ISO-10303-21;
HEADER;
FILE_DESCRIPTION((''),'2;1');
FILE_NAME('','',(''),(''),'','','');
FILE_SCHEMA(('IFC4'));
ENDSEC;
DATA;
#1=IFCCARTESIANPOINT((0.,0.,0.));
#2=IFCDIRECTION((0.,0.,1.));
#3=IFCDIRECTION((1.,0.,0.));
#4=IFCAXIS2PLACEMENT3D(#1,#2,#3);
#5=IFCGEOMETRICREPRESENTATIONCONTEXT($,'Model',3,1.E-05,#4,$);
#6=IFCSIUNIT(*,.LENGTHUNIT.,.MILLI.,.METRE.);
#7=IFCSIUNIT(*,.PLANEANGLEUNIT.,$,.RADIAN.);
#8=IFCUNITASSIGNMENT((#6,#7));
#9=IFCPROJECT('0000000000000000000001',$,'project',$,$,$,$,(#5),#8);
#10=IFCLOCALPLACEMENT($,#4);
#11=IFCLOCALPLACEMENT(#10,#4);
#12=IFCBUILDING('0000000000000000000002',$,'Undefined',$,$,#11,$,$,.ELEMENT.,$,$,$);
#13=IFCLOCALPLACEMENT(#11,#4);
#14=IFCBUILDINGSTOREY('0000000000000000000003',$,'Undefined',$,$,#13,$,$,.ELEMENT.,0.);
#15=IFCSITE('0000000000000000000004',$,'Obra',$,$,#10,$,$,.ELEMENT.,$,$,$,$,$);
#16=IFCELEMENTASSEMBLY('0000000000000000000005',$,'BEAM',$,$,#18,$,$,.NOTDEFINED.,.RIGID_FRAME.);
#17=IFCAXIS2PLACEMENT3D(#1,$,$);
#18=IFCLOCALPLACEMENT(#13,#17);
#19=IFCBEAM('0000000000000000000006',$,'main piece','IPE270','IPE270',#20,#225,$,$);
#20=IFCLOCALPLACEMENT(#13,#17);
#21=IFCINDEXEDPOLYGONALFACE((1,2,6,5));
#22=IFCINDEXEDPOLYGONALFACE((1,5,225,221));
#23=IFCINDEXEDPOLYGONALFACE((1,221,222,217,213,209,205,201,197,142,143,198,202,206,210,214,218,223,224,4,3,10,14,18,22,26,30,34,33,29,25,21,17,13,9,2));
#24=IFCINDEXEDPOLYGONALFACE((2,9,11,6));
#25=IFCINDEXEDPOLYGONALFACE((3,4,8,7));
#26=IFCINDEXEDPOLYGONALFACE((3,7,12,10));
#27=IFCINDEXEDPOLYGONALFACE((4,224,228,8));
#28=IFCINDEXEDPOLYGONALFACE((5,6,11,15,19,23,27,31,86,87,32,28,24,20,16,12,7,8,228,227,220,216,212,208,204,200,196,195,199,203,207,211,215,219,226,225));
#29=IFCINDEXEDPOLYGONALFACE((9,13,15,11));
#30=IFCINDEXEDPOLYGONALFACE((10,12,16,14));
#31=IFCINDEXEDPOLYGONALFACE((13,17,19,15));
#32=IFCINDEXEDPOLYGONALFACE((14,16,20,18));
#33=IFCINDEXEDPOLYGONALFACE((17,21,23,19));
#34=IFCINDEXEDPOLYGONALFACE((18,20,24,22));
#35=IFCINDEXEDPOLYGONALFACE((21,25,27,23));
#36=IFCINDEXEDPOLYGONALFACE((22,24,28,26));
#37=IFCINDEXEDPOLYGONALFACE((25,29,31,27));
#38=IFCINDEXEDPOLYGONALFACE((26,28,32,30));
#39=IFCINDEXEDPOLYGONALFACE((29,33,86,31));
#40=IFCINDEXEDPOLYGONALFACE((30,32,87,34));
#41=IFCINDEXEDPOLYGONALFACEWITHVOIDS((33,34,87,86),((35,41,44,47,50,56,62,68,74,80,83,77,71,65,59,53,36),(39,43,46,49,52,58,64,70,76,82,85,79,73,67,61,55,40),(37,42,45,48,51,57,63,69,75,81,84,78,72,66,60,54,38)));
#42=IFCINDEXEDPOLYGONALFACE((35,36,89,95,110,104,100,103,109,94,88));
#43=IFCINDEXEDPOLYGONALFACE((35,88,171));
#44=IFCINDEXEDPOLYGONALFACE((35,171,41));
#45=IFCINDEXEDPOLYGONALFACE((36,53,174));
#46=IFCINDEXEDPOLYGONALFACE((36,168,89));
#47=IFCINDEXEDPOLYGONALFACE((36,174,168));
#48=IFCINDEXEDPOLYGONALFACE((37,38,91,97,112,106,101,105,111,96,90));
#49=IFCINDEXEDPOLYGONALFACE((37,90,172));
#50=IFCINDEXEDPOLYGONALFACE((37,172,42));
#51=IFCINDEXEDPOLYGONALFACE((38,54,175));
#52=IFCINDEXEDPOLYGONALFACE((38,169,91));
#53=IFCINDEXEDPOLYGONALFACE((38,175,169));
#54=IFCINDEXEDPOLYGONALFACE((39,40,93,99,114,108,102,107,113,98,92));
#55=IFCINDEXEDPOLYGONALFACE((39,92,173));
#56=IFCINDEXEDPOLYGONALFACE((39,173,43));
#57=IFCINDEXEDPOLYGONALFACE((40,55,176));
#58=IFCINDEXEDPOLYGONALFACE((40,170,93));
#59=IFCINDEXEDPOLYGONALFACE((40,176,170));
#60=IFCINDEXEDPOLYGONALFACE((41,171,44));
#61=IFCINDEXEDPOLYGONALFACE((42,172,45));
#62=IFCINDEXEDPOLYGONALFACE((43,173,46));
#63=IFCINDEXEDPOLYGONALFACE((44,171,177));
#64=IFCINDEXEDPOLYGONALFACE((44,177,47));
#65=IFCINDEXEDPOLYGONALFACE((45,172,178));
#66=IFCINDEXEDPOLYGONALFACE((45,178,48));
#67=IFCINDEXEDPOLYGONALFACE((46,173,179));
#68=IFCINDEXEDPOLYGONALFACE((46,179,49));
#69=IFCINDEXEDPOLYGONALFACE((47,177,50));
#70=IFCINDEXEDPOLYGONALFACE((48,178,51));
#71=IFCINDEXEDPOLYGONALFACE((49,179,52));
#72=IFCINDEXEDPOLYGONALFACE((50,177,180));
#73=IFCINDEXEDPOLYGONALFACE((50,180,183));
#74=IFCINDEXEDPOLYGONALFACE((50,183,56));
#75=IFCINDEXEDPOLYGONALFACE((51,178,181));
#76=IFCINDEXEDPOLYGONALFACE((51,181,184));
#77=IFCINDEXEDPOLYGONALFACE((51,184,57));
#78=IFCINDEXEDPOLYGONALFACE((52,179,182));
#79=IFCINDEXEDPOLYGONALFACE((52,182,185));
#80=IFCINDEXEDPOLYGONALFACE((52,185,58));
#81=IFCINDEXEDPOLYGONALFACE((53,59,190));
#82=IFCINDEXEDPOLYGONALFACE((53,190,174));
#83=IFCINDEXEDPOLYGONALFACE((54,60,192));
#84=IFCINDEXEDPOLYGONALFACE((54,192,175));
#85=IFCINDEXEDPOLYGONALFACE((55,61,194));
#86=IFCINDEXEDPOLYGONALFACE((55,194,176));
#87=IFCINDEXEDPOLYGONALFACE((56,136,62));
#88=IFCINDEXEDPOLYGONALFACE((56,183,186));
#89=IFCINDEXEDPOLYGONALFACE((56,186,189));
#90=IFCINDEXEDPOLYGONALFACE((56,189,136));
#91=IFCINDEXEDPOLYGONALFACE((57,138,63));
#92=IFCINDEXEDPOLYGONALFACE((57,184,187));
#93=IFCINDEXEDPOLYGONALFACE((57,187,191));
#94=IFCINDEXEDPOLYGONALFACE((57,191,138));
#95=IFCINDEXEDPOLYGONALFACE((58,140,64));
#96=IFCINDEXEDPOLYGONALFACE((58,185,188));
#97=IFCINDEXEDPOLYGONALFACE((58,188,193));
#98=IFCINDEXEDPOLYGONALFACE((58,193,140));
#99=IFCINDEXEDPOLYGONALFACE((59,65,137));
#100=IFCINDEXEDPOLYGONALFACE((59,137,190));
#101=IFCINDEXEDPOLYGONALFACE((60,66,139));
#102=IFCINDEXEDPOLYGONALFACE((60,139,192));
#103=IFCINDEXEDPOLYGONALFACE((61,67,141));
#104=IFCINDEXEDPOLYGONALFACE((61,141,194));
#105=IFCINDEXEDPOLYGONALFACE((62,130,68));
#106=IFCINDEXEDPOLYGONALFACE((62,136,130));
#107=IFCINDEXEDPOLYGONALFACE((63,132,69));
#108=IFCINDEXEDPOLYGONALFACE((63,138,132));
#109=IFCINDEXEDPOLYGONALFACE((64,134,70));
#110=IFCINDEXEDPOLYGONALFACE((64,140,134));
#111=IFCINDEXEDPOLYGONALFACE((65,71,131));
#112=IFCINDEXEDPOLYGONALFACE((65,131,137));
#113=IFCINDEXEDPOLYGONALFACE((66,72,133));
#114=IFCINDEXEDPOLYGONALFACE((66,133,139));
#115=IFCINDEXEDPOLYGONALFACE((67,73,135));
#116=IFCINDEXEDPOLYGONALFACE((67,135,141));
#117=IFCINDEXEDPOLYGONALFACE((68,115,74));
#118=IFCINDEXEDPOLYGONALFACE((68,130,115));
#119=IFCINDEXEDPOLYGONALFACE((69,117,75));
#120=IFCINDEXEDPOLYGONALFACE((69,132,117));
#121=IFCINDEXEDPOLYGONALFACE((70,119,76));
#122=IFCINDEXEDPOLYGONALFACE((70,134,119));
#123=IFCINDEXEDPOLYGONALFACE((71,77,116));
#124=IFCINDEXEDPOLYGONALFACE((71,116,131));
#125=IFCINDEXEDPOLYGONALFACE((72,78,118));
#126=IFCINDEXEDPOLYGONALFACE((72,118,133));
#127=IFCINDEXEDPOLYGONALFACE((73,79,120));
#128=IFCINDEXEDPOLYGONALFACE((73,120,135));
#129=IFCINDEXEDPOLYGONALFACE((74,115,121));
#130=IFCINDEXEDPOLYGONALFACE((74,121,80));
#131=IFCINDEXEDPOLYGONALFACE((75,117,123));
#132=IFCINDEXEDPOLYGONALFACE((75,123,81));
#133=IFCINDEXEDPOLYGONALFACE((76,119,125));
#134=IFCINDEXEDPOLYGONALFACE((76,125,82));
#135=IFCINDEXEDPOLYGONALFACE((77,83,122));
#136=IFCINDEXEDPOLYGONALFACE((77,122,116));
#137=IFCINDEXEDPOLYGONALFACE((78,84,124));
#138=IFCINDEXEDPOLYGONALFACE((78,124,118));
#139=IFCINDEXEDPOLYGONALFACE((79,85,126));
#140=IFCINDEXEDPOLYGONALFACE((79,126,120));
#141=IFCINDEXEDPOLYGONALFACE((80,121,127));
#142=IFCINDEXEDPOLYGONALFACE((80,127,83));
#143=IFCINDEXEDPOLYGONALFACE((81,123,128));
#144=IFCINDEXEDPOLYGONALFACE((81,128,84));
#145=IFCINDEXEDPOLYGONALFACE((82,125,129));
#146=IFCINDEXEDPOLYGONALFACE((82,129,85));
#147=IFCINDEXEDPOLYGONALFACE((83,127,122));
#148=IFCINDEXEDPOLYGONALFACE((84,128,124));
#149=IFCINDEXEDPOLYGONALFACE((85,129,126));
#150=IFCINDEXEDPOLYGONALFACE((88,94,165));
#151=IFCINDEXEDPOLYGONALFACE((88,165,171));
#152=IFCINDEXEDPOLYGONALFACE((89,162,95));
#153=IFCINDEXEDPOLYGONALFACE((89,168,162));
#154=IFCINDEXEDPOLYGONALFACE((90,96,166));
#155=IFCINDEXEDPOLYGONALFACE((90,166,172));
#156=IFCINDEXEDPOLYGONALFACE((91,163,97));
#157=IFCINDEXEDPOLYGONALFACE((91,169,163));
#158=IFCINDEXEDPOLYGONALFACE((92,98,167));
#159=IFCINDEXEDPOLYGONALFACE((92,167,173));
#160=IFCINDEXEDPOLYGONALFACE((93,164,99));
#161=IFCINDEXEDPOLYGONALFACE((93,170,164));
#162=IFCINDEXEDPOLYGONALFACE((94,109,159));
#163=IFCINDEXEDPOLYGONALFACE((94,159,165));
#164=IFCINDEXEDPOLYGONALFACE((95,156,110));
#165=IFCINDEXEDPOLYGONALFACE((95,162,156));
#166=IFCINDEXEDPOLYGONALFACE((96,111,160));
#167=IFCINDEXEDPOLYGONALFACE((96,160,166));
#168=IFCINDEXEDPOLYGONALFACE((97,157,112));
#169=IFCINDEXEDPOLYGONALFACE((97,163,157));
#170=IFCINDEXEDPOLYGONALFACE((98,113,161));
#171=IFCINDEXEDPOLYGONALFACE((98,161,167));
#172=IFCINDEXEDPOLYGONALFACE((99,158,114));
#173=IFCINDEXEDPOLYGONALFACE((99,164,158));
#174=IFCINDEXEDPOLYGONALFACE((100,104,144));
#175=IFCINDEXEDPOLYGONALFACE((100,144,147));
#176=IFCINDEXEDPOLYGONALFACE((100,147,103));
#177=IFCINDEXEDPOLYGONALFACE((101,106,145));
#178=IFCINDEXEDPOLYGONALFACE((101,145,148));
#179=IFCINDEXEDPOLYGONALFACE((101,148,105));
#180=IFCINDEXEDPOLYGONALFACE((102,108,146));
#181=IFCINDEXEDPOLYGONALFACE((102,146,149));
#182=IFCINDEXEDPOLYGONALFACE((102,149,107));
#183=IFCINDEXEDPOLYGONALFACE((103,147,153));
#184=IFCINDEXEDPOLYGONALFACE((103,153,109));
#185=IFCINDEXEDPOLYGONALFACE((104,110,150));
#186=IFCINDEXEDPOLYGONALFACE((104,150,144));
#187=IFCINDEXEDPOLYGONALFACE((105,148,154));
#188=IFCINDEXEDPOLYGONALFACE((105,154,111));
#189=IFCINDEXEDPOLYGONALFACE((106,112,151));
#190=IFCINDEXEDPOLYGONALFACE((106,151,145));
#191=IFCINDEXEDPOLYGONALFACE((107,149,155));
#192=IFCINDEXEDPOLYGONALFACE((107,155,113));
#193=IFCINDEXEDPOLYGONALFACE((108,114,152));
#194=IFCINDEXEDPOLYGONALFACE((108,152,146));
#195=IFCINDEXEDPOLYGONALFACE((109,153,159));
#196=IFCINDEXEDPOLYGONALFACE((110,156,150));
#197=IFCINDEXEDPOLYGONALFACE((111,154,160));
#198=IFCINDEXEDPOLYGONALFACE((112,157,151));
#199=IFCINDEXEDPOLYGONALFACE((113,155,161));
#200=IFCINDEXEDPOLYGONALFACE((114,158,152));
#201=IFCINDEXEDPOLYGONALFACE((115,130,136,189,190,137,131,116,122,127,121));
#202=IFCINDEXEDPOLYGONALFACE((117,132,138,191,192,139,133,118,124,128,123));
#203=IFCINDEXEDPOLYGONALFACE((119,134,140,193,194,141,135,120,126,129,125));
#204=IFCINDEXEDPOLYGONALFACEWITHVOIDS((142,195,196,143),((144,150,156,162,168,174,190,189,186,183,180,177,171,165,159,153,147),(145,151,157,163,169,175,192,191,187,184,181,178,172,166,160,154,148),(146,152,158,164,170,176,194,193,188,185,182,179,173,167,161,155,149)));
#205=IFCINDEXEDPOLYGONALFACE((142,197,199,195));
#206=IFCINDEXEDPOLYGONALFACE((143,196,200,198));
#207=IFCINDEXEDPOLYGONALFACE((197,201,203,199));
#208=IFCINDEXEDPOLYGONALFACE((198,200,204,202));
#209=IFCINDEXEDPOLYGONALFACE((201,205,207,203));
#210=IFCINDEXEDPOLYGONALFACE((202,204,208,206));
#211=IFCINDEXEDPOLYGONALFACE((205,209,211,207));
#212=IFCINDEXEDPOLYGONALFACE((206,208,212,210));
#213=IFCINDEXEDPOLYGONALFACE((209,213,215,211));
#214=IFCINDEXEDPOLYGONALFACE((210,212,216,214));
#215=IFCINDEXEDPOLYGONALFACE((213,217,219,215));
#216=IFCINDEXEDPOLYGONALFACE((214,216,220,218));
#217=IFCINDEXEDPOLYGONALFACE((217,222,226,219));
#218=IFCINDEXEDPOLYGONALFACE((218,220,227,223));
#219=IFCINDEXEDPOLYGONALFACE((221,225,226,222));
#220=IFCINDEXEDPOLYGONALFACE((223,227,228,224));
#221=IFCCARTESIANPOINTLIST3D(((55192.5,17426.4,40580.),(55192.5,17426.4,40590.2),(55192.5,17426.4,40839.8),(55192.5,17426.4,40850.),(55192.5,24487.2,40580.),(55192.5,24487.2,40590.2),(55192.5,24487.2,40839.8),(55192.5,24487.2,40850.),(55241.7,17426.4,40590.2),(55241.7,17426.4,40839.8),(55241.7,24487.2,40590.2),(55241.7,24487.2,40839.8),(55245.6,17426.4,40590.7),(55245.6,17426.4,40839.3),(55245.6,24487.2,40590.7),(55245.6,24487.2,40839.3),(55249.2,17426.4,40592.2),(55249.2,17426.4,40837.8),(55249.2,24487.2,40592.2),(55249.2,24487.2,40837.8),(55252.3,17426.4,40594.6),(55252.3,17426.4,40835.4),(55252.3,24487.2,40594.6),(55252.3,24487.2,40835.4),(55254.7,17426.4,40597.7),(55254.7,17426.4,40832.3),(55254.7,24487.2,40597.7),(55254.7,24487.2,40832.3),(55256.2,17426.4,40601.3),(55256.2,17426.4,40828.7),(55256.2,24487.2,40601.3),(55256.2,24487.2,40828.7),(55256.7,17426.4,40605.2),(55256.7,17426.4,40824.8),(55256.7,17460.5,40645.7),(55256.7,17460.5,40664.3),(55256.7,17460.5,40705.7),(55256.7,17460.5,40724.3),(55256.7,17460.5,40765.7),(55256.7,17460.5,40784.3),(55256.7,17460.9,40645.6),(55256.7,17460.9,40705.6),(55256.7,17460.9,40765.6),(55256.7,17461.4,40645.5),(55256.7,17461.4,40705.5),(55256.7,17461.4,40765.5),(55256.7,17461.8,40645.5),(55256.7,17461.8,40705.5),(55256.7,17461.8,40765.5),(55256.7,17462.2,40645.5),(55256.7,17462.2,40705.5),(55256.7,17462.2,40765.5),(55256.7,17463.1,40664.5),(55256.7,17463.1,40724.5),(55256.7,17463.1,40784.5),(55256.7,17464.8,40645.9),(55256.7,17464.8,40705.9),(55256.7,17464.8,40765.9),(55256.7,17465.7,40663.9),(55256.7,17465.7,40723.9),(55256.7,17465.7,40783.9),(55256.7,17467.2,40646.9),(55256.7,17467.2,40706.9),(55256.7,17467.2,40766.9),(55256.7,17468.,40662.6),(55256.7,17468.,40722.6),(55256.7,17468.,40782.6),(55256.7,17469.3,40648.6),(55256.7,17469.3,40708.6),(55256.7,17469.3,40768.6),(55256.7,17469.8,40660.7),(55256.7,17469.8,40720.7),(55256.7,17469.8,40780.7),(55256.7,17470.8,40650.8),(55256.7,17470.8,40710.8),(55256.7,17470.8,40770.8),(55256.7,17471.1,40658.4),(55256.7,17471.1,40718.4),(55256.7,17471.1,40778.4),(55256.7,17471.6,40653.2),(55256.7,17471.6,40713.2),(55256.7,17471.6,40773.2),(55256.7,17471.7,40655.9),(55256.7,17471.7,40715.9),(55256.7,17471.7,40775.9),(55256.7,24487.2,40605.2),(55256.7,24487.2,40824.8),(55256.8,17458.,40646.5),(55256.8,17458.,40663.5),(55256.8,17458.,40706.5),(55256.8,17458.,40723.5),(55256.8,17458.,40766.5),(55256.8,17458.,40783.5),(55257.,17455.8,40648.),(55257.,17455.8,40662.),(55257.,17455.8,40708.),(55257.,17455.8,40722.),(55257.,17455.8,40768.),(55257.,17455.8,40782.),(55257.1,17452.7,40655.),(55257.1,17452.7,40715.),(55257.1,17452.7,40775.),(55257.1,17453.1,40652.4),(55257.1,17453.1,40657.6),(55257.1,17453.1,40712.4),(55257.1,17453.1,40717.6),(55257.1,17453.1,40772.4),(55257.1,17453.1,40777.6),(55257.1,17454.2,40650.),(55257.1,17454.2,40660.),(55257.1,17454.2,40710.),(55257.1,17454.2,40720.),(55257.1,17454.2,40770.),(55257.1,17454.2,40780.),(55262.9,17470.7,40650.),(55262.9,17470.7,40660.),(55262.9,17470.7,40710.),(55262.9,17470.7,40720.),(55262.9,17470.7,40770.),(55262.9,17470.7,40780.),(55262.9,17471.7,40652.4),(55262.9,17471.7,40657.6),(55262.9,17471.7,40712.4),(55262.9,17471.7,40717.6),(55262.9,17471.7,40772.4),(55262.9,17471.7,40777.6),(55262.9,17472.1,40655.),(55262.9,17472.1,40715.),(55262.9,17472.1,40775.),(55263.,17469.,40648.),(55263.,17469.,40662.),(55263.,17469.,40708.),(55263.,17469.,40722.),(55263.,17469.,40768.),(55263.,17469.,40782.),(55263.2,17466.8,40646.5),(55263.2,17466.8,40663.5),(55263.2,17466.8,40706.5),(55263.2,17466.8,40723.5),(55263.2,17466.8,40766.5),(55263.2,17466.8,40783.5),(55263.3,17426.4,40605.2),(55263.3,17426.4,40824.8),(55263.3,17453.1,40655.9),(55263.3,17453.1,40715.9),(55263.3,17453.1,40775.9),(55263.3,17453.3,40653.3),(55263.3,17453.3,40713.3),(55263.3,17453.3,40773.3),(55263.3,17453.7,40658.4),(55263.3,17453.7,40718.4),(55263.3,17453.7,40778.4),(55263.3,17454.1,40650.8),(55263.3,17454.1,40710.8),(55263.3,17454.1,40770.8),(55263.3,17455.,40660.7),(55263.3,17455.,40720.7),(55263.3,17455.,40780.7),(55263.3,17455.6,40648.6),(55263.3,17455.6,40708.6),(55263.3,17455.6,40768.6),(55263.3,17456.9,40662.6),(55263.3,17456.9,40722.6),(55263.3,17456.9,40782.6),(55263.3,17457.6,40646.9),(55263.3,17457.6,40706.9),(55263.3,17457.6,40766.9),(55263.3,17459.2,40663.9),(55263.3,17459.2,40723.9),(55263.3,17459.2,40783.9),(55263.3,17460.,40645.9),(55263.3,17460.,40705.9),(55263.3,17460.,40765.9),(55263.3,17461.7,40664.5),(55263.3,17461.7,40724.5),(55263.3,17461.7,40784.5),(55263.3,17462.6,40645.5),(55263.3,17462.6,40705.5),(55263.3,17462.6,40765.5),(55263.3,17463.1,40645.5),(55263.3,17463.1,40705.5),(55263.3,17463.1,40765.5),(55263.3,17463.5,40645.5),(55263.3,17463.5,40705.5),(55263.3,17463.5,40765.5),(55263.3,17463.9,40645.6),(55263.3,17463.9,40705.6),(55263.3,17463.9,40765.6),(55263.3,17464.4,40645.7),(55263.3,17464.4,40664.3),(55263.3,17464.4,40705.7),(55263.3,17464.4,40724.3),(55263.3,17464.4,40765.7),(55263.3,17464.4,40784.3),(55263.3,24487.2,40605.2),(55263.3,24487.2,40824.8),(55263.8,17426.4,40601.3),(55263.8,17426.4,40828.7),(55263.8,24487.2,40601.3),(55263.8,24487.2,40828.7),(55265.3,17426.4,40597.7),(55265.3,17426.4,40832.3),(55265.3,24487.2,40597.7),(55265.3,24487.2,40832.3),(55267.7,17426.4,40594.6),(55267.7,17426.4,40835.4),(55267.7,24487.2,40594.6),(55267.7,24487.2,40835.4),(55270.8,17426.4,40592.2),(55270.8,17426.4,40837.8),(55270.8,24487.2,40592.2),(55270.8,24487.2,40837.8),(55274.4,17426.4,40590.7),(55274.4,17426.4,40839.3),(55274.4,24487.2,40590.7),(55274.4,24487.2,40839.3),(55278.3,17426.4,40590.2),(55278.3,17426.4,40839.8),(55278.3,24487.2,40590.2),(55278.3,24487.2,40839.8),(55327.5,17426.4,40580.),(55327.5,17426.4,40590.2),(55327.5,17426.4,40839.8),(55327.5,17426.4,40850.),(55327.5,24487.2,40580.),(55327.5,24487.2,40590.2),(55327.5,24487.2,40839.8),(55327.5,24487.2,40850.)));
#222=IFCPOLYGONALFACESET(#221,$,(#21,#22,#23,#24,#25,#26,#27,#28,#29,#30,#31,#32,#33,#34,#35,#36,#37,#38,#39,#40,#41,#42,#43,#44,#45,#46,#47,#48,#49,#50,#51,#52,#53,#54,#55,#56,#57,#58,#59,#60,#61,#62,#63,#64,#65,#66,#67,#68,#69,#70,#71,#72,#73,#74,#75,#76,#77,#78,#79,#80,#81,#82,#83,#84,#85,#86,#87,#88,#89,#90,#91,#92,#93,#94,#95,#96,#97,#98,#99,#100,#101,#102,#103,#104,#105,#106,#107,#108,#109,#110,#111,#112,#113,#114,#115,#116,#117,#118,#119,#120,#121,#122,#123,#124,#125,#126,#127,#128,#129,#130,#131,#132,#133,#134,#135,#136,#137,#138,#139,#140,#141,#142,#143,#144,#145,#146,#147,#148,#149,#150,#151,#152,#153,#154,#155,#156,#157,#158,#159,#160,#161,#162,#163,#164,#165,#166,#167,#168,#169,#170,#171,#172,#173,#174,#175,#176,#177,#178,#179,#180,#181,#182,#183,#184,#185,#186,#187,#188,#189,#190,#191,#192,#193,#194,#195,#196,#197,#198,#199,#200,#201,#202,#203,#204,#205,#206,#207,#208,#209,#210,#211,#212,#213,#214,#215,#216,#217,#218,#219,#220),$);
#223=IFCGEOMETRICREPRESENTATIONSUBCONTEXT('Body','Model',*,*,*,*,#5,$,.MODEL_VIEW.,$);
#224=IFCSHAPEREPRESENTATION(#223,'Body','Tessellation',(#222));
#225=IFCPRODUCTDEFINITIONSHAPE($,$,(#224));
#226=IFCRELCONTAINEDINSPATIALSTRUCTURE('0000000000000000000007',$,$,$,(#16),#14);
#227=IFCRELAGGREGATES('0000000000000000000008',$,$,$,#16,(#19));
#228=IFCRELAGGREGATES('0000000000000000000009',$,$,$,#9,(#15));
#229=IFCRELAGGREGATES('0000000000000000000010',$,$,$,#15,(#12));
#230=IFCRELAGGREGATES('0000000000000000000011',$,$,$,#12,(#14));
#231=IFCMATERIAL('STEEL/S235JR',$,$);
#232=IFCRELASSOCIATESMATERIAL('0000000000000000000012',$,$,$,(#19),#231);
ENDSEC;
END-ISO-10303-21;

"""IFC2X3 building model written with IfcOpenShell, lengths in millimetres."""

from ifc_helpers import new_model, si_unit, frame, origin_with_axes, origin_2d_with_axis, place, context, subcontext, project, spatial, circle, i_section, extrude, clip, halfspace, source, transform, mapped, material, element, aggregate, save


model = new_model("IFC2X3")

# Units and contexts
model_context = context("Model", 3, precision=1e-05, world=origin_with_axes())
body_context = subcontext(model_context, "Body", "Model", "MODEL_VIEW")
ifc_project = project(units=[si_unit("LENGTHUNIT", "METRE", prefix="MILLI"), si_unit("PLANEANGLEUNIT", "RADIAN")], contexts=[model_context])

# Site, building, storey
site_placement = place(None, origin_with_axes())
site = spatial("IfcSite", under=ifc_project, at=site_placement, Name="Obra", CompositionType="ELEMENT")
building_placement = place(site_placement, origin_with_axes())
building = spatial("IfcBuilding", under=site, at=building_placement, Name="Undefined", CompositionType="ELEMENT")
storey_placement = place(building_placement, origin_with_axes())
storey = spatial("IfcBuildingStorey", under=building, at=storey_placement, Name="Undefined", CompositionType="ELEMENT", Elevation=0.0)

# Shared definitions
ifc_material_1 = material(Name="STEEL/S235JR")

# Shared definitions
shared_shape_1 = source(origin_with_axes(), body_context, "Body", "SweptSolid", [
    extrude(circle(Radius=9.5, at=origin_2d_with_axis()), frame((0.0, -35.4, 0.0), z_axis=(0.0, 1.0, 0.0), x_axis=(1.0, 0.0, 0.0)), (0.0, 0.0, 1.0), 6.8),
])

# Element assembly, beam, opening
assembly_1_placement = place(storey_placement, origin_with_axes())
assembly_1 = element("IfcElementAssembly", 1, at=assembly_1_placement, inside=storey, Name="BEAM", AssemblyPlace="NOTDEFINED", PredefinedType="RIGID_FRAME")
beam_1_placement = place(assembly_1_placement, frame((55260.0, 24487.2, 40715.0), z_axis=(0.0, 0.0, 1.0), x_axis=(0.0, -1.0, 0.0)))
beam_1 = element("IfcBeam", 2, at=beam_1_placement, material=ifc_material_1, Name="main piece", Description="IPE270", ObjectType="IPE270", context=body_context, shape_type="Clipping", body=[
    clip(extrude(i_section(OverallWidth=135.0, OverallDepth=270.0, WebThickness=6.6, FlangeThickness=10.2, FilletRadius=15.0, at=origin_2d_with_axis()), frame((7060.8, 0.0, 0.0), z_axis=(-1.0, 0.0, 0.0), x_axis=(0.0, -1.0, 0.0)), (0.0, 0.0, 1.0), 7060.8), halfspace(frame((7079.5, -89.1, -120.0), z_axis=(0.998367, 0.057126, 0.0), x_axis=(0.0, 0.0, 1.0)), False)),
])
opening_1_placement = place(assembly_1_placement, frame((55230.9, 17410.7, 40835.0), z_axis=(-0.057107, 0.998368, 0.0), x_axis=(0.0, 0.0, -1.0)))
element("IfcOpeningElement", 3, at=opening_1_placement, cuts=beam_1, ObjectType="Opening", context=body_context, shape_type="MappedRepresentation", body=[
    mapped(shared_shape_1, transform((60.0, 0.0, 50.0))),
    mapped(shared_shape_1, transform((120.0, 0.0, 50.0))),
    mapped(shared_shape_1, transform((180.0, 0.0, 50.0))),
])

aggregate(assembly_1, [beam_1])

save(model, "model.ifc")
